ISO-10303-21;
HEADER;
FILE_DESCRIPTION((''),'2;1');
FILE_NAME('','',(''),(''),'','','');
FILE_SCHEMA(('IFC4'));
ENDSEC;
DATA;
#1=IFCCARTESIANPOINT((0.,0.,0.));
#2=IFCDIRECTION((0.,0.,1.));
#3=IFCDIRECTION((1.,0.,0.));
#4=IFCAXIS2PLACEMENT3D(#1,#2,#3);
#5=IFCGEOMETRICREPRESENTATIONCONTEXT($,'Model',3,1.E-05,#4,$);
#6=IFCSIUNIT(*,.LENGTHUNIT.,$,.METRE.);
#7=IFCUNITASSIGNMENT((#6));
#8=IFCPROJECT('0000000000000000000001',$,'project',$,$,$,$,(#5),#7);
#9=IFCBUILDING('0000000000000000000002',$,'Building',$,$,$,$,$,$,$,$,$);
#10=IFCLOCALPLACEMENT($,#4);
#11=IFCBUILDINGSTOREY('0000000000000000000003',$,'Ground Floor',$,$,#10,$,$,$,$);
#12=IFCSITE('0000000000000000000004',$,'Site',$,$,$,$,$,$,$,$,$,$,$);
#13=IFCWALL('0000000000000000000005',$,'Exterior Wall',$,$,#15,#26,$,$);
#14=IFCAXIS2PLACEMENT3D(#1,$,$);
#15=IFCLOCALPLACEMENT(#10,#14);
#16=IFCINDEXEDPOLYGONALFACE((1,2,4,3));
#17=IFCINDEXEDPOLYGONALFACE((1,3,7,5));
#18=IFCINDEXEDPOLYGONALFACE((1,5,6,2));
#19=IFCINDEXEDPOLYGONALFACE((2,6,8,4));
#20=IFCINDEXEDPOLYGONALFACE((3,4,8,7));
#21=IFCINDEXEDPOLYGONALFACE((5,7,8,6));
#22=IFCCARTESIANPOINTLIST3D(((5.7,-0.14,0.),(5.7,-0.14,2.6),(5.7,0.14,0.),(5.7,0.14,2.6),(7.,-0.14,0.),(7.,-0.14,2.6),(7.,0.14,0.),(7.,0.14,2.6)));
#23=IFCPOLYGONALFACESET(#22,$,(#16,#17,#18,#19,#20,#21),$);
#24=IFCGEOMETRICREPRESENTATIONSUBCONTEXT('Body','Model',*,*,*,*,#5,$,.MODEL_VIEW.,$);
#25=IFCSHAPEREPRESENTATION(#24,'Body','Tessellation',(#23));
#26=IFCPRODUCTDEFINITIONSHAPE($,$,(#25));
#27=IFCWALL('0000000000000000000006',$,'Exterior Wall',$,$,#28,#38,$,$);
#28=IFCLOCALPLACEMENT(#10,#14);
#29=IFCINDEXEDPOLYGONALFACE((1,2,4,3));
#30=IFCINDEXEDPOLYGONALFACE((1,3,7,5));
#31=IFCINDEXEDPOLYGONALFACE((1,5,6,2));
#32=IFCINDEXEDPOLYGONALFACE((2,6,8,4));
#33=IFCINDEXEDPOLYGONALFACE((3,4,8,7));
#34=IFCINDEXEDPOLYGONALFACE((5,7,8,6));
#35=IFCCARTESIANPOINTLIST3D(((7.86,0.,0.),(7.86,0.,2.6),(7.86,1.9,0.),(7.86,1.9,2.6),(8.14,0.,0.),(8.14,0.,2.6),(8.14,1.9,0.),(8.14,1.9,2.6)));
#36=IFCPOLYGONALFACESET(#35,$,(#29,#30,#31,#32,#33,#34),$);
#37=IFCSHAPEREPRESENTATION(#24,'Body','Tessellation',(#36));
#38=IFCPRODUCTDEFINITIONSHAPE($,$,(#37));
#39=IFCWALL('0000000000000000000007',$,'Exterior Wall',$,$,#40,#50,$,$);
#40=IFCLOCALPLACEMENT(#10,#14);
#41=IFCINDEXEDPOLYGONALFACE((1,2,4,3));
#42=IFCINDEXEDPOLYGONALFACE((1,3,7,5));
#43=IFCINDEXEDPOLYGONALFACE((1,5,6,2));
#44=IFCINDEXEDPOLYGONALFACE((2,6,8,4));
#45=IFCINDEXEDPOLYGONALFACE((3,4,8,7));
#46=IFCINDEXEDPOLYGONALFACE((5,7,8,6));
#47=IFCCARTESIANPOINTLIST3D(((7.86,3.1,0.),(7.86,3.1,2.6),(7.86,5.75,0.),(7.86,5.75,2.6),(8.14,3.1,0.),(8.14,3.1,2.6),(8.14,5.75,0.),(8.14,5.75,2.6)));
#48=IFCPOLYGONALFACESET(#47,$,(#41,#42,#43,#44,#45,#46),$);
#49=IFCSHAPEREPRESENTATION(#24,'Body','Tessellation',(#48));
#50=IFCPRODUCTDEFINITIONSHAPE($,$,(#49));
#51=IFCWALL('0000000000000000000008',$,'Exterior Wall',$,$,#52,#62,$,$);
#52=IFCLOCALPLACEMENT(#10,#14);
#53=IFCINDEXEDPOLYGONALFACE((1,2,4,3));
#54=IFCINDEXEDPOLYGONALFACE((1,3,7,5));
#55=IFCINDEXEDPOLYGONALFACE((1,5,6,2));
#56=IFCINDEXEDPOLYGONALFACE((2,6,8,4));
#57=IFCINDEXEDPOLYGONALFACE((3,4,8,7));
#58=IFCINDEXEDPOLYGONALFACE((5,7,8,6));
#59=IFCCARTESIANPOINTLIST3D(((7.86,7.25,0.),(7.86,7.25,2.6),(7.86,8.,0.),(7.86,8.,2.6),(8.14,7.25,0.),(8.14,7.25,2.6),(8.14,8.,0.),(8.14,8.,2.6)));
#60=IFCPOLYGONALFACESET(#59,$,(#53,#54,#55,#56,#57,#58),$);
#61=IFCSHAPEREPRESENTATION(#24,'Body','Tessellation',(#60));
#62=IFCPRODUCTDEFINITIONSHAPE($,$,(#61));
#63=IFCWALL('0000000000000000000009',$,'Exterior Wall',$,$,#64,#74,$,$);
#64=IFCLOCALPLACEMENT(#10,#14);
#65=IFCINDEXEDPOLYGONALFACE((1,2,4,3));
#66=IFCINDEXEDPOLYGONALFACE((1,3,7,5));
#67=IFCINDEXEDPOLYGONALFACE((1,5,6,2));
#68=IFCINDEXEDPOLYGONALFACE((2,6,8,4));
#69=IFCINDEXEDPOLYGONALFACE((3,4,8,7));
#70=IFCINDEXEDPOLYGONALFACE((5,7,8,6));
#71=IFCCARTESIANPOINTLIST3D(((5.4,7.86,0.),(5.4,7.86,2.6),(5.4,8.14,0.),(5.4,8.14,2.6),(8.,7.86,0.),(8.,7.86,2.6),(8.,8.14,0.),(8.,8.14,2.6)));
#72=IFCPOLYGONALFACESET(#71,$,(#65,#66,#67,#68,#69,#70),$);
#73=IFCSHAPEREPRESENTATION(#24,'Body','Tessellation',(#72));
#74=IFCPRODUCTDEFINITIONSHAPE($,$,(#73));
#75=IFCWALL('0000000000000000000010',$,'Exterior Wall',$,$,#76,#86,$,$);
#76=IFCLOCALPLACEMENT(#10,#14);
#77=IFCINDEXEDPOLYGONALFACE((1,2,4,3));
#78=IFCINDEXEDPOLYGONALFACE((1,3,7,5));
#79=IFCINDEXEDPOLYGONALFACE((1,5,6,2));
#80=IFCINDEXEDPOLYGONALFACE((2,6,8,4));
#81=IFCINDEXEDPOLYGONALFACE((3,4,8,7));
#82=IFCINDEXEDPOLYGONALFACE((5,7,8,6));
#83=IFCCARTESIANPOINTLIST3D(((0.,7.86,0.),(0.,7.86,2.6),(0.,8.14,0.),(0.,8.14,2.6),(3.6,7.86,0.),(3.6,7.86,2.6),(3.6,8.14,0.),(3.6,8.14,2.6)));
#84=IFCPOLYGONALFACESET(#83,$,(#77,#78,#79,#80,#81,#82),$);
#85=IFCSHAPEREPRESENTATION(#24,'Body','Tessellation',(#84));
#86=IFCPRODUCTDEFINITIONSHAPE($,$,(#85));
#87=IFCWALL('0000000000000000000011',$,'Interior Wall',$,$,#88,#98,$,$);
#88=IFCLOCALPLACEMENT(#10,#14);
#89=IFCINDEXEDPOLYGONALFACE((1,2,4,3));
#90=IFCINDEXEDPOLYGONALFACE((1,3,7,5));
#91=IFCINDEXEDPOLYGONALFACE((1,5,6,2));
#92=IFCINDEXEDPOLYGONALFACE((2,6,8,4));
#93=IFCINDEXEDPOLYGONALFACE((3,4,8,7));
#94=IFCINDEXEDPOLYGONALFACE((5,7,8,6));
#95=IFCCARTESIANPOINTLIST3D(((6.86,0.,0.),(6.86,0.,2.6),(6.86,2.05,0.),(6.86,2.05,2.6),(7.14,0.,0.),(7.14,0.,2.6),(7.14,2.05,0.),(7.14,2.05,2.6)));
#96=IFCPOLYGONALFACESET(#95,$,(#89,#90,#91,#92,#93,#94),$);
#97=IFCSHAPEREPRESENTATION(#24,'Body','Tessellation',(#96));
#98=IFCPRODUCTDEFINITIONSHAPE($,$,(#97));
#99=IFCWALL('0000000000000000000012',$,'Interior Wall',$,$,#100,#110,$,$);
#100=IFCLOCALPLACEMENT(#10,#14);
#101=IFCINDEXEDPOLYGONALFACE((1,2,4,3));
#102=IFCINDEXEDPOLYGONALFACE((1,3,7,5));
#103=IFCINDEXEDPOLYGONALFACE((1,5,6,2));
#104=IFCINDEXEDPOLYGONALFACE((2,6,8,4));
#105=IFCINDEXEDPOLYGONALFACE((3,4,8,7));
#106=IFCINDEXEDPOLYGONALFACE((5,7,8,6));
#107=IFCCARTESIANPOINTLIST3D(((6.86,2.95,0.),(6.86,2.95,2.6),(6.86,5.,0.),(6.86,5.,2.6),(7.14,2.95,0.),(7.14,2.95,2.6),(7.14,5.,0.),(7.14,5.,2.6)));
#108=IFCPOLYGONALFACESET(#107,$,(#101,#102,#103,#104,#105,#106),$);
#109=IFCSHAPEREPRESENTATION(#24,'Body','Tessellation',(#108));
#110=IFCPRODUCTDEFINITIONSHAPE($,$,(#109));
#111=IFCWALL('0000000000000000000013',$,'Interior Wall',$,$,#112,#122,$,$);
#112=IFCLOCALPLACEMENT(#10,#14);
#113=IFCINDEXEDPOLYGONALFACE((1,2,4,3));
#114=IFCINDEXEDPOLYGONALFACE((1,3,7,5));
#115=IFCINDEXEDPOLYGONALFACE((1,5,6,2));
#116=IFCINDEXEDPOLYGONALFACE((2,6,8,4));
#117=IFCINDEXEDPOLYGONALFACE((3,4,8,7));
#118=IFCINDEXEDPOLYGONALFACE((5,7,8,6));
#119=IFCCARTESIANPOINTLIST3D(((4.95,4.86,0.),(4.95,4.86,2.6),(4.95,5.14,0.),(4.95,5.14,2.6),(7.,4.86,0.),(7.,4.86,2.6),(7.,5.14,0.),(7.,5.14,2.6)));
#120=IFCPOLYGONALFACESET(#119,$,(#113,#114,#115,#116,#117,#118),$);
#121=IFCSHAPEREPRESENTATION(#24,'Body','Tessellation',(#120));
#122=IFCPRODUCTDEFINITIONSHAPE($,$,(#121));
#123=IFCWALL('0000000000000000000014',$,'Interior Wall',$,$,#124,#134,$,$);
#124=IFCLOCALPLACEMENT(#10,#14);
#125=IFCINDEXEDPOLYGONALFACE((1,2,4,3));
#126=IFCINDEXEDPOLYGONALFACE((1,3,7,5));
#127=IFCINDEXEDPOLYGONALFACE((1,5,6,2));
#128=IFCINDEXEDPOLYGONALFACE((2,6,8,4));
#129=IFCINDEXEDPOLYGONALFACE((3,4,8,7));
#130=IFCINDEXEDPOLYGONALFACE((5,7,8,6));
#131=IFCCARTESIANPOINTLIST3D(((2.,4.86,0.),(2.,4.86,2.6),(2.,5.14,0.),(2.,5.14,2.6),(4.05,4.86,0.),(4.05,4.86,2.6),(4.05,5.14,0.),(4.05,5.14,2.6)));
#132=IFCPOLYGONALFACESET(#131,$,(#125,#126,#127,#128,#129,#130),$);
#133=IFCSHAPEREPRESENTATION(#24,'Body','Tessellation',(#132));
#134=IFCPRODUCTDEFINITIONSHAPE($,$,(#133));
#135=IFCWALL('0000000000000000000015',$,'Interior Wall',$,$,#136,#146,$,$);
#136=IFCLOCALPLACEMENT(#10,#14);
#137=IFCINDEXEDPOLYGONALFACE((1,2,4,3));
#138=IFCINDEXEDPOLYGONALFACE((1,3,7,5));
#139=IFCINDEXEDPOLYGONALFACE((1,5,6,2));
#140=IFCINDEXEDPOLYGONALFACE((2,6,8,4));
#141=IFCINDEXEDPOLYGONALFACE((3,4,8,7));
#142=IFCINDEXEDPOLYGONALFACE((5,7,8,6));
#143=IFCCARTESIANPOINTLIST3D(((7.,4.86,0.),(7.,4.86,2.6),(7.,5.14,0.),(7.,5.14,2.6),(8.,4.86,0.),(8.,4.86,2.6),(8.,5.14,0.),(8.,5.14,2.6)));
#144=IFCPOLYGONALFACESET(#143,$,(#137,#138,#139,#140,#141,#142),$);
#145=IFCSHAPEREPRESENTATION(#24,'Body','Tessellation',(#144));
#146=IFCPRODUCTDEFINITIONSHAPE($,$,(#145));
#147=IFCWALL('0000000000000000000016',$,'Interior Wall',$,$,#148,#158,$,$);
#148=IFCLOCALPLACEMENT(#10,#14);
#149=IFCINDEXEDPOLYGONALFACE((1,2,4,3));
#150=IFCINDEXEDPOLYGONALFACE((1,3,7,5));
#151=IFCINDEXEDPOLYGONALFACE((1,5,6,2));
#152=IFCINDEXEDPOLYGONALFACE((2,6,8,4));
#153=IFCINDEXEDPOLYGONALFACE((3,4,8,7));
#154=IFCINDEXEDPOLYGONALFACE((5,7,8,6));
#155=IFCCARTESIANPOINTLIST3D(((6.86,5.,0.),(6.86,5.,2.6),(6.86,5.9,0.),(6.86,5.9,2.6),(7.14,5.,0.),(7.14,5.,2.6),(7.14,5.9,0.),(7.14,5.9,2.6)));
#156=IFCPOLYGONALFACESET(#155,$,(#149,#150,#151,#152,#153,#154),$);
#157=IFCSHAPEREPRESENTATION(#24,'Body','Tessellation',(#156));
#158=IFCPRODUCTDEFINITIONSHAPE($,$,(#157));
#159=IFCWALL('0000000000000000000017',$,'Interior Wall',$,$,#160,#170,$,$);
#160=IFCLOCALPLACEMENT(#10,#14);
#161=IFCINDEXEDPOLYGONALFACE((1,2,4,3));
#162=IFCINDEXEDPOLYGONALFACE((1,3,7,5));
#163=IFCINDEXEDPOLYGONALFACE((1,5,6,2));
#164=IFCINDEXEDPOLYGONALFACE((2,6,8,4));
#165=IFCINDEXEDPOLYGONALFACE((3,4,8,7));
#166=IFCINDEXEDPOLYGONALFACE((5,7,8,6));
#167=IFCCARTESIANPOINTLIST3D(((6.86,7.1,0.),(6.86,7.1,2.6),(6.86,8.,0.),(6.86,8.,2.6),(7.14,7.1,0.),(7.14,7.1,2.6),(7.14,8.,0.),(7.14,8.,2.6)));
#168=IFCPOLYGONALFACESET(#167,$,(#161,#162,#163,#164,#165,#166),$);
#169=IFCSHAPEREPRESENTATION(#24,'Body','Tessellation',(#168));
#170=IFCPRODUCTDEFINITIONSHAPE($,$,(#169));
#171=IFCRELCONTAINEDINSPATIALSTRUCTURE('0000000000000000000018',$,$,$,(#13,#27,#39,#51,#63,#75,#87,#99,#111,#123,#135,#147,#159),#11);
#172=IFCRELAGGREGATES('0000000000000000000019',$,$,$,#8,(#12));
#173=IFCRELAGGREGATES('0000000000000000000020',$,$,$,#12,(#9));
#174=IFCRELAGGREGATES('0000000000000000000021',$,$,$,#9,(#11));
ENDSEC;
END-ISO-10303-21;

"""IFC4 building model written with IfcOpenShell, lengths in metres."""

from ifc_helpers import new_model, si_unit, frame, origin_with_axes, place, context, subcontext, project, spatial, indexed_curve, outline, extrude, element, save


model = new_model("IFC4")

# Units and contexts
model_context = context("Model", 3, precision=1e-05, world=origin_with_axes())
body_context = subcontext(model_context, "Body", "Model", "MODEL_VIEW")
ifc_project = project(units=[si_unit("LENGTHUNIT", "METRE")], contexts=[model_context])

# Site, building, storey
site = spatial("IfcSite", under=ifc_project, Name="Site")
building = spatial("IfcBuilding", under=site, Name="Building")
storey_placement = place(None, origin_with_axes())
storey = spatial("IfcBuildingStorey", under=building, at=storey_placement, Name="Ground Floor")

# Walls
wall_1_placement = place(storey_placement, frame((5.7, 0.0, 0.0), z_axis=(0.0, 0.0, 1.0), x_axis=(1.0, 0.0, 0.0)))
element("IfcWall", 1, at=wall_1_placement, inside=storey, Name="Exterior Wall", context=body_context, shape_type="SweptSolid", body=[
    extrude(outline(indexed_curve([(0.0, 0.0), (0.0, 0.28), (1.3, 0.28), (1.3, 0.0), (0.0, 0.0)], self_intersect=False)), frame((0.0, -0.14, 0.0), z_axis=(0.0, 0.0, 1.0), x_axis=(1.0, 0.0, 0.0)), (0.0, 0.0, 1.0), 2.6),
])
wall_2_placement = place(storey_placement, frame((8.0, 0.0, 0.0), z_axis=(0.0, 0.0, 1.0), x_axis=(0.0, 1.0, 0.0)))
element("IfcWall", 2, at=wall_2_placement, inside=storey, Name="Exterior Wall", context=body_context, shape_type="SweptSolid", body=[
    extrude(outline(indexed_curve([(0.0, 0.0), (0.0, 0.28), (1.9, 0.28), (1.9, 0.0), (0.0, 0.0)], self_intersect=False)), frame((0.0, -0.14, 0.0), z_axis=(0.0, 0.0, 1.0), x_axis=(1.0, 0.0, 0.0)), (0.0, 0.0, 1.0), 2.6),
])
wall_3_placement = place(storey_placement, frame((8.0, 3.1, 0.0), z_axis=(0.0, 0.0, 1.0), x_axis=(0.0, 1.0, 0.0)))
element("IfcWall", 3, at=wall_3_placement, inside=storey, Name="Exterior Wall", context=body_context, shape_type="SweptSolid", body=[
    extrude(outline(indexed_curve([(0.0, 0.0), (0.0, 0.28), (2.65, 0.28), (2.65, 0.0), (0.0, 0.0)], self_intersect=False)), frame((0.0, -0.14, 0.0), z_axis=(0.0, 0.0, 1.0), x_axis=(1.0, 0.0, 0.0)), (0.0, 0.0, 1.0), 2.6),
])
wall_4_placement = place(storey_placement, frame((8.0, 7.25, 0.0), z_axis=(0.0, 0.0, 1.0), x_axis=(0.0, 1.0, 0.0)))
element("IfcWall", 4, at=wall_4_placement, inside=storey, Name="Exterior Wall", context=body_context, shape_type="SweptSolid", body=[
    extrude(outline(indexed_curve([(0.0, 0.0), (0.0, 0.28), (0.75, 0.28), (0.75, 0.0), (0.0, 0.0)], self_intersect=False)), frame((0.0, -0.14, 0.0), z_axis=(0.0, 0.0, 1.0), x_axis=(1.0, 0.0, 0.0)), (0.0, 0.0, 1.0), 2.6),
])
wall_5_placement = place(storey_placement, frame((8.0, 8.0, 0.0), z_axis=(0.0, 0.0, 1.0), x_axis=(-1.0, 0.0, 0.0)))
element("IfcWall", 5, at=wall_5_placement, inside=storey, Name="Exterior Wall", context=body_context, shape_type="SweptSolid", body=[
    extrude(outline(indexed_curve([(0.0, 0.0), (0.0, 0.28), (2.6, 0.28), (2.6, 0.0), (0.0, 0.0)], self_intersect=False)), frame((0.0, -0.14, 0.0), z_axis=(0.0, 0.0, 1.0), x_axis=(1.0, 0.0, 0.0)), (0.0, 0.0, 1.0), 2.6),
])
wall_6_placement = place(storey_placement, frame((3.6, 8.0, 0.0), z_axis=(0.0, 0.0, 1.0), x_axis=(-1.0, 0.0, 0.0)))
element("IfcWall", 6, at=wall_6_placement, inside=storey, Name="Exterior Wall", context=body_context, shape_type="SweptSolid", body=[
    extrude(outline(indexed_curve([(0.0, 0.0), (0.0, 0.28), (3.6, 0.28), (3.6, 0.0), (0.0, 0.0)], self_intersect=False)), frame((0.0, -0.14, 0.0), z_axis=(0.0, 0.0, 1.0), x_axis=(1.0, 0.0, 0.0)), (0.0, 0.0, 1.0), 2.6),
])
for number, where, z_axis, x_axis, name in (
    (7, (7.0, 0.0, 0.0), (0.0, 0.0, 1.0), (0.0, 1.0, 0.0), "Interior Wall"),
    (8, (7.0, 2.95, 0.0), (0.0, 0.0, 1.0), (0.0, 1.0, 0.0), "Interior Wall"),
    (9, (7.0, 5.0, 0.0), (0.0, 0.0, 1.0), (-1.0, 0.0, 0.0), "Interior Wall"),
    (10, (4.05, 5.0, 0.0), (0.0, 0.0, 1.0), (-1.0, 0.0, 0.0), "Interior Wall"),
):
    element("IfcWall", number, at=place(storey_placement, frame(where, z_axis=z_axis, x_axis=x_axis)), inside=storey, Name=name, context=body_context, shape_type="SweptSolid", body=[
        extrude(outline(indexed_curve([(0.0, 0.0), (0.0, 0.28), (2.05, 0.28), (2.05, 0.0), (0.0, 0.0)], self_intersect=False)), frame((0.0, -0.14, 0.0), z_axis=(0.0, 0.0, 1.0), x_axis=(1.0, 0.0, 0.0)), (0.0, 0.0, 1.0), 2.6),
    ])
wall_7_placement = place(storey_placement, frame((8.0, 5.0, 0.0), z_axis=(0.0, 0.0, 1.0), x_axis=(-1.0, 0.0, 0.0)))
element("IfcWall", 11, at=wall_7_placement, inside=storey, Name="Interior Wall", context=body_context, shape_type="SweptSolid", body=[
    extrude(outline(indexed_curve([(0.0, 0.0), (0.0, 0.28), (1.0, 0.28), (1.0, 0.0), (0.0, 0.0)], self_intersect=False)), frame((0.0, -0.14, 0.0), z_axis=(0.0, 0.0, 1.0), x_axis=(1.0, 0.0, 0.0)), (0.0, 0.0, 1.0), 2.6),
])
for number, where, z_axis, x_axis, name in (
    (12, (7.0, 5.0, 0.0), (0.0, 0.0, 1.0), (0.0, 1.0, 0.0), "Interior Wall"),
    (13, (7.0, 7.1, 0.0), (0.0, 0.0, 1.0), (0.0, 1.0, 0.0), "Interior Wall"),
):
    element("IfcWall", number, at=place(storey_placement, frame(where, z_axis=z_axis, x_axis=x_axis)), inside=storey, Name=name, context=body_context, shape_type="SweptSolid", body=[
        extrude(outline(indexed_curve([(0.0, 0.0), (0.0, 0.28), (0.9, 0.28), (0.9, 0.0), (0.0, 0.0)], self_intersect=False)), frame((0.0, -0.14, 0.0), z_axis=(0.0, 0.0, 1.0), x_axis=(1.0, 0.0, 0.0)), (0.0, 0.0, 1.0), 2.6),
    ])

save(model, "model.ifc")
